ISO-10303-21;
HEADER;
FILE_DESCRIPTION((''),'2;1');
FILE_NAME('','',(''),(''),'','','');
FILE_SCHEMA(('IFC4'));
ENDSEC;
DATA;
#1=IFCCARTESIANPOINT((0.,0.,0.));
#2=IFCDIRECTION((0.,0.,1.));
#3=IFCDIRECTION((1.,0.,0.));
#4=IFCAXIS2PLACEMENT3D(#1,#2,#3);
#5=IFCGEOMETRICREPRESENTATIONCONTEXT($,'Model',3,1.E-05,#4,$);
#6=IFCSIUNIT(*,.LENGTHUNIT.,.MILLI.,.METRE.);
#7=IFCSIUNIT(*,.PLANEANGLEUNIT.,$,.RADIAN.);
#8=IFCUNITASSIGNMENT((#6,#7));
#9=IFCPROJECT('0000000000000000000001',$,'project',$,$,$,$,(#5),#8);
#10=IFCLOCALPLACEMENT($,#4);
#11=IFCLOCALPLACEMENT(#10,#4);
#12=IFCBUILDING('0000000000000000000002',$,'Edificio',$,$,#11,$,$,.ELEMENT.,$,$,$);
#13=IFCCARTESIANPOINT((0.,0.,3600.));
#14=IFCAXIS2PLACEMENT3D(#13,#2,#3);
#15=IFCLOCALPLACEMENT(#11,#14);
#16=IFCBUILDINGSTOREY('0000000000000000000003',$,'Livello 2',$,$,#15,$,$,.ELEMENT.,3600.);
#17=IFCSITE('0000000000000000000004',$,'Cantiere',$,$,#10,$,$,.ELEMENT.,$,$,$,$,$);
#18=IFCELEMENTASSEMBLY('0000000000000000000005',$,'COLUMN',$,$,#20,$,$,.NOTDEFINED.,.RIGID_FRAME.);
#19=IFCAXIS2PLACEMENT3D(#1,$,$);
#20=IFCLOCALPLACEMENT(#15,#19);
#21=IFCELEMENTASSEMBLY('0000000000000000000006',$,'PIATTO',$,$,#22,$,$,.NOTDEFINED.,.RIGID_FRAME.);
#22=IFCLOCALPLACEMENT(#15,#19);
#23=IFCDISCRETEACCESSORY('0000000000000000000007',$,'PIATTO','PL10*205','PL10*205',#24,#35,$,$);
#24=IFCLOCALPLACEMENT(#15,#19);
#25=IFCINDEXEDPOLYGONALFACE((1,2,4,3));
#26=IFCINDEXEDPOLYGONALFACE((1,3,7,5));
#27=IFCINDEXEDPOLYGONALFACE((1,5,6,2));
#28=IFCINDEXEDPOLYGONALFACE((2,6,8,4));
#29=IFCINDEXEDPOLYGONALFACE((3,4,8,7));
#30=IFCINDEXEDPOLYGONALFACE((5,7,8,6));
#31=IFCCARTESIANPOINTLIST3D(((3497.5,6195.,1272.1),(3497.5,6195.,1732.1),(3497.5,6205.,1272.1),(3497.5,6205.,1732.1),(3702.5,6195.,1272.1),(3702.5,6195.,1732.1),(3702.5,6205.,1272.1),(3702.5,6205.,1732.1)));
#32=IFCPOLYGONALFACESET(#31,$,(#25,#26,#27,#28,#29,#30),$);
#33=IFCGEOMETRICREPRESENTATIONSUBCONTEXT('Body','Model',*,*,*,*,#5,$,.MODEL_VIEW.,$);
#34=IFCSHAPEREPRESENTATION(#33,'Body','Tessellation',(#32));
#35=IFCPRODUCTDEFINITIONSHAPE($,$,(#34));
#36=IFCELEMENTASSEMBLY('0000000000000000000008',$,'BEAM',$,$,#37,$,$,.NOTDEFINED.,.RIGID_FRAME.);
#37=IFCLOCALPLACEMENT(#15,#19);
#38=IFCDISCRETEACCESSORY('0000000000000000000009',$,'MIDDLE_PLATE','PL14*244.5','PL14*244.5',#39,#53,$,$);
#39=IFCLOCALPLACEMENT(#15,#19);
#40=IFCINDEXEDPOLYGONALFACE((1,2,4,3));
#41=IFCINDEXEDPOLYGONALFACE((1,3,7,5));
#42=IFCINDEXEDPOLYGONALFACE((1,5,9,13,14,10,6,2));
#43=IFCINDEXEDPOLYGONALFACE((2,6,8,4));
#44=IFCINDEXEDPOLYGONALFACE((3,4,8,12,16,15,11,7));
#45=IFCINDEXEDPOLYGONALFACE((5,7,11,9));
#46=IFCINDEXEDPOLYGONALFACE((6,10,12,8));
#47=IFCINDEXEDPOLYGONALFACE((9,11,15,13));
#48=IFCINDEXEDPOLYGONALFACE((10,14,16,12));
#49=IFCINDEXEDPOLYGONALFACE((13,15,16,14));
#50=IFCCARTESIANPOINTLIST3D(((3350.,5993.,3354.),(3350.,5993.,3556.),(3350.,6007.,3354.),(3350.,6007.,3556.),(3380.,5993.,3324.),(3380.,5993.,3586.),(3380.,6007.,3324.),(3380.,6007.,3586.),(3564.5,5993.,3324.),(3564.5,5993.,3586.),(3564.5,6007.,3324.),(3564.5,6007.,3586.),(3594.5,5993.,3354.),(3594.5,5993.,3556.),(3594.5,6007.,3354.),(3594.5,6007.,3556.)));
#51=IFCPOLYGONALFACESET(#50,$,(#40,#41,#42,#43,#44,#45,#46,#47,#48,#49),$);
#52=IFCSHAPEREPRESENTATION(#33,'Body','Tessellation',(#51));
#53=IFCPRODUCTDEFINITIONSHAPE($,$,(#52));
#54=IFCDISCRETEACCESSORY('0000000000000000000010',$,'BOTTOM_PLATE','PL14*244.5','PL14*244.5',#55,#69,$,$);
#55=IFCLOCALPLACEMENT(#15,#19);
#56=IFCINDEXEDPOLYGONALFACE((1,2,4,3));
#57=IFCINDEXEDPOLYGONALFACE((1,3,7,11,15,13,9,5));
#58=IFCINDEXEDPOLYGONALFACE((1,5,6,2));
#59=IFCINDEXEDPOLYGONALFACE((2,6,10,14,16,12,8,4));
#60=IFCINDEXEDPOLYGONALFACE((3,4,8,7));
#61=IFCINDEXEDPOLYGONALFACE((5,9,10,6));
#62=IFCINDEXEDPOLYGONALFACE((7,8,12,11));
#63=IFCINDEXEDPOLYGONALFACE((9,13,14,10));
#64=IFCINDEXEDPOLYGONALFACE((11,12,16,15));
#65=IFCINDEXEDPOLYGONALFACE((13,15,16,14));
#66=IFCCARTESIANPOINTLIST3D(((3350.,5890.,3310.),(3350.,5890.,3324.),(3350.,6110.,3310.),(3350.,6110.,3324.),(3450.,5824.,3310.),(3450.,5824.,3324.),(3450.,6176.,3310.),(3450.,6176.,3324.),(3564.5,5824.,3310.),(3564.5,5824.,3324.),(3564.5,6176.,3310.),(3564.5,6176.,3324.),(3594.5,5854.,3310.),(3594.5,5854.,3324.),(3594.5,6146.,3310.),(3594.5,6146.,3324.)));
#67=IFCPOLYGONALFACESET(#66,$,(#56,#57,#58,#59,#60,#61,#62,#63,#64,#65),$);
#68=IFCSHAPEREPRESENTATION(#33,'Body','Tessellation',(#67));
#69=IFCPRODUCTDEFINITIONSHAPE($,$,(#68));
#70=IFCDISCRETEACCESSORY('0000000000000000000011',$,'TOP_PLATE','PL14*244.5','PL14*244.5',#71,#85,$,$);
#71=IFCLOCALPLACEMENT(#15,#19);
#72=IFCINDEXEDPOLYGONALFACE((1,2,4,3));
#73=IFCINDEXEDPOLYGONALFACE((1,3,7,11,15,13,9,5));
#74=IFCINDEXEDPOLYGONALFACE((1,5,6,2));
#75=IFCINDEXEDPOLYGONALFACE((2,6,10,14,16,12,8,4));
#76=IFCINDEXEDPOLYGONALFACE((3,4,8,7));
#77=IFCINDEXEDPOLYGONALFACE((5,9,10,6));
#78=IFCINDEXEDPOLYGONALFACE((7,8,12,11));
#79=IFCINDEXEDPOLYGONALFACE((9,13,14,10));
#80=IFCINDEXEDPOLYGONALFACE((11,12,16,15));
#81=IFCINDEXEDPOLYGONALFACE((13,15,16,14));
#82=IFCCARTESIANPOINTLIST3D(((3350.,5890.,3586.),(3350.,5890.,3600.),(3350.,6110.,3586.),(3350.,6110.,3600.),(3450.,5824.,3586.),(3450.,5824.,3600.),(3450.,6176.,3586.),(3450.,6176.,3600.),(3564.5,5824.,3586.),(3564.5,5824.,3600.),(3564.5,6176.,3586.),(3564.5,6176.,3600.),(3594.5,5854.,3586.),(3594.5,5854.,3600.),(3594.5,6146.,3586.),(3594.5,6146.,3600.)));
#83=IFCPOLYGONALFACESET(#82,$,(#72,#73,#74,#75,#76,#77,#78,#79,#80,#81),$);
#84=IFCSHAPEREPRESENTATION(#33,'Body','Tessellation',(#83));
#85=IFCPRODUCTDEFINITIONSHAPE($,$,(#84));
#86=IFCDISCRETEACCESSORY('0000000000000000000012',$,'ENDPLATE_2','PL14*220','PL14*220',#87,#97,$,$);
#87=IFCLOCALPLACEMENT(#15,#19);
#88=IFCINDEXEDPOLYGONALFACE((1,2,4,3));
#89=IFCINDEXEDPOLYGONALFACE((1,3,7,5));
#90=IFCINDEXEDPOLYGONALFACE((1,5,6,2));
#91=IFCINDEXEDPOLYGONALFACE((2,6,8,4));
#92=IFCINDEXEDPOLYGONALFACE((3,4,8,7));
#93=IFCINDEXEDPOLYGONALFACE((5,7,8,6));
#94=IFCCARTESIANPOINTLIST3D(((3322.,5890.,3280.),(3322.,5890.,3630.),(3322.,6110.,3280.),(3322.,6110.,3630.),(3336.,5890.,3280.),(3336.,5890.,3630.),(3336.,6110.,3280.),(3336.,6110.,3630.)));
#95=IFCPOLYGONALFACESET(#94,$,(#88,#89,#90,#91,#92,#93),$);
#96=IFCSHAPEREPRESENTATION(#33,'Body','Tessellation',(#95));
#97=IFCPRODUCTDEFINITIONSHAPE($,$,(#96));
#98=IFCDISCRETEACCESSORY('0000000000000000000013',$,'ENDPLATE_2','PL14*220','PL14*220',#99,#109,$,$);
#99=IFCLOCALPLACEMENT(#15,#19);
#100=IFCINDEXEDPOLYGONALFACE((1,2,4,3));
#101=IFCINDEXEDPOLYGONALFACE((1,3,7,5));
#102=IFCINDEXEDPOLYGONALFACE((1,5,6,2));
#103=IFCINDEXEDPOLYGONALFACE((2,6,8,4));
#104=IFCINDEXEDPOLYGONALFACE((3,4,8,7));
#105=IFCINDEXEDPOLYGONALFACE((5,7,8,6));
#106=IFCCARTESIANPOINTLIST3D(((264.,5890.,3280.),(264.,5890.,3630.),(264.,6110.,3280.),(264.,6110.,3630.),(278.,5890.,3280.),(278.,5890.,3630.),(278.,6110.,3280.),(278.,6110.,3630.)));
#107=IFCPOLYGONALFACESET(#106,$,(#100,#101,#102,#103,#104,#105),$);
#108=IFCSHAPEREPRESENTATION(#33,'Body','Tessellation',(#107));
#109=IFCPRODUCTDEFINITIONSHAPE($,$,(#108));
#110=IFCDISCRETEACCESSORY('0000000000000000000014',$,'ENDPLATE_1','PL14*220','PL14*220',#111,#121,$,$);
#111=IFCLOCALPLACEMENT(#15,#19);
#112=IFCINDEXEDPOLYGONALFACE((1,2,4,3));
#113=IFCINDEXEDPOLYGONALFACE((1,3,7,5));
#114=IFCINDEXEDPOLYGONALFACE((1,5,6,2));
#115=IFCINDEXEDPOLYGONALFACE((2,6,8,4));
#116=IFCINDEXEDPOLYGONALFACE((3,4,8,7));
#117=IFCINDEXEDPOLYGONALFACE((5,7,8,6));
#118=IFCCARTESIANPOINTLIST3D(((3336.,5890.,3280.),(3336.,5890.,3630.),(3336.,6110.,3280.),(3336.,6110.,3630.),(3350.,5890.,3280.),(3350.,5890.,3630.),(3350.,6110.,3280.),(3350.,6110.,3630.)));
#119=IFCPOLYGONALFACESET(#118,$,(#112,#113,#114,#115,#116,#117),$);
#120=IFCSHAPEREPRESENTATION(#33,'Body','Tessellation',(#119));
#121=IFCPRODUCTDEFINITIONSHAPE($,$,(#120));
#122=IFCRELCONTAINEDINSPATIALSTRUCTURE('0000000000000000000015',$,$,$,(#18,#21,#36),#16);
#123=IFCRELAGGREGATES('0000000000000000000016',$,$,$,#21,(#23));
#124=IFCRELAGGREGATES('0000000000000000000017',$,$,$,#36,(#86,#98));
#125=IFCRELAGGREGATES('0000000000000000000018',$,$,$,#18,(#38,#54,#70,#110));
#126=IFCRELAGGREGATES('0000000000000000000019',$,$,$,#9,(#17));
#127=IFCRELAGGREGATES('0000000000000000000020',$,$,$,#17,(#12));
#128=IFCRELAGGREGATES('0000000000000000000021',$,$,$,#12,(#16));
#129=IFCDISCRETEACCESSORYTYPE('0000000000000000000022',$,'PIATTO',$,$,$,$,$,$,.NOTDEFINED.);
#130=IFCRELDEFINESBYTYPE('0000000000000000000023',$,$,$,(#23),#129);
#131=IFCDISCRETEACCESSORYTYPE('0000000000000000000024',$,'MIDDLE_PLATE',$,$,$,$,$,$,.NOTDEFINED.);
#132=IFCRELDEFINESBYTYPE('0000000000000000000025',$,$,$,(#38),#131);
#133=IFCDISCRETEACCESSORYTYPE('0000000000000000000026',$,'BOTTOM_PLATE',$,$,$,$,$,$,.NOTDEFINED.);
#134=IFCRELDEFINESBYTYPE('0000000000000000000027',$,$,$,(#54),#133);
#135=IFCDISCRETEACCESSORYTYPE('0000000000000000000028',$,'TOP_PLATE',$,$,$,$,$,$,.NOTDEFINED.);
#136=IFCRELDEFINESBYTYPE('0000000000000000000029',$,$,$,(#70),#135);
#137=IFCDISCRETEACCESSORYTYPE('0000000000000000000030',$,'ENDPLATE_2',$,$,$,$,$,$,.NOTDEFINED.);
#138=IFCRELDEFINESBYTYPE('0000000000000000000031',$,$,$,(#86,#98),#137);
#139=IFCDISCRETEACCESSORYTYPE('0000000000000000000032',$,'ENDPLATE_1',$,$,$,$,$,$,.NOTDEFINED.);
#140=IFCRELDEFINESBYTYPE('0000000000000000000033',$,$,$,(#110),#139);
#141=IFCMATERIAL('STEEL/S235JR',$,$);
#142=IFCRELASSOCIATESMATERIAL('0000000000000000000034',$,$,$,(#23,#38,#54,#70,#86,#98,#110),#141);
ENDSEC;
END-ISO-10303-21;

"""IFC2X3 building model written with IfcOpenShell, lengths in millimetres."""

from ifc_helpers import new_model, si_unit, frame, origin_with_axes, place, context, subcontext, project, spatial, polyline, outline, extrude, material, type_object, element, aggregate, save


model = new_model("IFC2X3")

# Units and contexts
model_context = context("Model", 3, precision=1e-05, world=origin_with_axes())
body_context = subcontext(model_context, "Body", "Model", "MODEL_VIEW")
ifc_project = project(units=[si_unit("LENGTHUNIT", "METRE", prefix="MILLI"), si_unit("PLANEANGLEUNIT", "RADIAN")], contexts=[model_context])

# Site, building, storey
site_placement = place(None, origin_with_axes())
site = spatial("IfcSite", under=ifc_project, at=site_placement, Name="Cantiere", CompositionType="ELEMENT")
building_placement = place(site_placement, origin_with_axes())
building = spatial("IfcBuilding", under=site, at=building_placement, Name="Edificio", CompositionType="ELEMENT")
storey_placement = place(building_placement, frame((0.0, 0.0, 3600.0), z_axis=(0.0, 0.0, 1.0), x_axis=(1.0, 0.0, 0.0)))
storey = spatial("IfcBuildingStorey", under=building, at=storey_placement, Name="Livello 2", CompositionType="ELEMENT", Elevation=3600.0)

# Element assembly
assembly_1_placement = place(storey_placement, origin_with_axes())
assembly_1 = element("IfcElementAssembly", 1, at=assembly_1_placement, inside=storey, Name="COLUMN", AssemblyPlace="NOTDEFINED", PredefinedType="RIGID_FRAME")
ifc_material_1 = material(Name="STEEL/S235JR")

# Shared definitions
discrete_accessory_type_1 = type_object("IfcDiscreteAccessoryType", Name="PIATTO")

# Element assembly, discrete accessory
assembly_2_placement = place(storey_placement, origin_with_axes())
assembly_2 = element("IfcElementAssembly", 2, at=assembly_2_placement, inside=storey, Name="PIATTO", AssemblyPlace="NOTDEFINED", PredefinedType="RIGID_FRAME")
discrete_accessory_1_placement = place(assembly_2_placement, frame((3600.0, 6200.0, 1272.1), z_axis=(0.0, -1.0, 0.0), x_axis=(0.0, 0.0, 1.0)))
discrete_accessory_1 = element("IfcDiscreteAccessory", 3, at=discrete_accessory_1_placement, type_object=discrete_accessory_type_1, material=ifc_material_1, Name="PIATTO", Description="PL10*205", ObjectType="PL10*205", context=body_context, shape_type="SweptSolid", body=[
    extrude(outline(polyline([(0.0, 102.5), (460.0, 102.5), (460.0, -102.5), (0.0, -102.5), (0.0, 102.5)])), frame((0.0, 0.0, -5.0), z_axis=(0.0, 0.0, 1.0), x_axis=(1.0, 0.0, 0.0)), (0.0, 0.0, 1.0), 10.0),
])
aggregate(assembly_2, [discrete_accessory_1])

# Element assembly
assembly_3_placement = place(storey_placement, origin_with_axes())
assembly_3 = element("IfcElementAssembly", 4, at=assembly_3_placement, inside=storey, Name="BEAM", AssemblyPlace="NOTDEFINED", PredefinedType="RIGID_FRAME")

# Discrete accessories
discrete_accessory_type_2 = type_object("IfcDiscreteAccessoryType", Name="MIDDLE_PLATE")
discrete_accessory_2_placement = place(assembly_1_placement, frame((3350.0, 6000.0, 3586.0), z_axis=(0.0, 1.0, 0.0), x_axis=(1.0, 0.0, 0.0)))
discrete_accessory_2 = element("IfcDiscreteAccessory", 5, at=discrete_accessory_2_placement, type_object=discrete_accessory_type_2, material=ifc_material_1, Name="MIDDLE_PLATE", Description="PL14*244.5", ObjectType="PL14*244.5", context=body_context, shape_type="SweptSolid", body=[
    extrude(outline(polyline([(0.0, 30.0), (30.0, 0.0), (214.5, 0.0), (244.5, 30.0), (244.5, 232.0), (214.5, 262.0), (30.0, 262.0), (0.0, 232.0), (0.0, 30.0)])), frame((0.0, 0.0, -7.0), z_axis=(0.0, 0.0, 1.0), x_axis=(1.0, 0.0, 0.0)), (0.0, 0.0, 1.0), 14.0),
])
discrete_accessory_type_3 = type_object("IfcDiscreteAccessoryType", Name="BOTTOM_PLATE")
discrete_accessory_3_placement = place(assembly_1_placement, frame((3594.5, 5824.0, 3317.0), z_axis=(0.0, 0.0, 1.0), x_axis=(0.0, 1.0, 0.0)))
discrete_accessory_3 = element("IfcDiscreteAccessory", 6, at=discrete_accessory_3_placement, type_object=discrete_accessory_type_3, material=ifc_material_1, Name="BOTTOM_PLATE", Description="PL14*244.5", ObjectType="PL14*244.5", context=body_context, shape_type="SweptSolid", body=[
    extrude(outline(polyline([(0.0, 30.0), (30.0, 0.0), (322.0, 0.0), (352.0, 30.0), (352.0, 144.5), (286.0, 244.5), (66.0, 244.5), (0.0, 144.5), (0.0, 30.0)])), frame((0.0, 0.0, -7.0), z_axis=(0.0, 0.0, 1.0), x_axis=(1.0, 0.0, 0.0)), (0.0, 0.0, 1.0), 14.0),
])
discrete_accessory_type_4 = type_object("IfcDiscreteAccessoryType", Name="TOP_PLATE")
discrete_accessory_4_placement = place(assembly_1_placement, frame((3450.0, 5824.0, 3593.0), z_axis=(0.0, 0.0, 1.0), x_axis=(1.0, 0.0, 0.0)))
discrete_accessory_4 = element("IfcDiscreteAccessory", 7, at=discrete_accessory_4_placement, type_object=discrete_accessory_type_4, material=ifc_material_1, Name="TOP_PLATE", Description="PL14*244.5", ObjectType="PL14*244.5", context=body_context, shape_type="SweptSolid", body=[
    extrude(outline(polyline([(0.0, 0.0), (114.5, 0.0), (144.5, 30.0), (144.5, 322.0), (114.5, 352.0), (0.0, 352.0), (-100.0, 286.0), (-100.0, 66.0), (0.0, 0.0)])), frame((0.0, 0.0, -7.0), z_axis=(0.0, 0.0, 1.0), x_axis=(1.0, 0.0, 0.0)), (0.0, 0.0, 1.0), 14.0),
])
discrete_accessory_type_5 = type_object("IfcDiscreteAccessoryType", Name="ENDPLATE_2")
discrete_accessory_5_placement = place(assembly_3_placement, frame((3329.0, 5890.0, 3280.0), z_axis=(-1.0, 0.0, 0.0), x_axis=(0.0, 0.0, 1.0)))
discrete_accessory_5 = element("IfcDiscreteAccessory", 8, at=discrete_accessory_5_placement, type_object=discrete_accessory_type_5, material=ifc_material_1, Name="ENDPLATE_2", Description="PL14*220", ObjectType="PL14*220", context=body_context, shape_type="SweptSolid", body=[
    extrude(outline(polyline([(0.0, 0.0), (350.0, 0.0), (350.0, 220.0), (0.0, 220.0), (0.0, 0.0)])), frame((0.0, 0.0, -7.0), z_axis=(0.0, 0.0, 1.0), x_axis=(1.0, 0.0, 0.0)), (0.0, 0.0, 1.0), 14.0),
])
discrete_accessory_6_placement = place(assembly_3_placement, frame((271.0, 6110.0, 3280.0), z_axis=(1.0, 0.0, 0.0), x_axis=(0.0, 0.0, 1.0)))
discrete_accessory_6 = element("IfcDiscreteAccessory", 9, at=discrete_accessory_6_placement, type_object=discrete_accessory_type_5, material=ifc_material_1, Name="ENDPLATE_2", Description="PL14*220", ObjectType="PL14*220", context=body_context, shape_type="SweptSolid", body=[
    extrude(outline(polyline([(0.0, 0.0), (350.0, 0.0), (350.0, 220.0), (0.0, 220.0), (0.0, 0.0)])), frame((0.0, 0.0, -7.0), z_axis=(0.0, 0.0, 1.0), x_axis=(1.0, 0.0, 0.0)), (0.0, 0.0, 1.0), 14.0),
])
aggregate(assembly_3, [discrete_accessory_5, discrete_accessory_6])
discrete_accessory_type_6 = type_object("IfcDiscreteAccessoryType", Name="ENDPLATE_1")
discrete_accessory_7_placement = place(assembly_1_placement, frame((3343.0, 5890.0, 3280.0), z_axis=(-1.0, 0.0, 0.0), x_axis=(0.0, 0.0, 1.0)))
discrete_accessory_7 = element("IfcDiscreteAccessory", 10, at=discrete_accessory_7_placement, type_object=discrete_accessory_type_6, material=ifc_material_1, Name="ENDPLATE_1", Description="PL14*220", ObjectType="PL14*220", context=body_context, shape_type="SweptSolid", body=[
    extrude(outline(polyline([(0.0, 0.0), (350.0, 0.0), (350.0, 220.0), (0.0, 220.0), (0.0, 0.0)])), frame((0.0, 0.0, -7.0), z_axis=(0.0, 0.0, 1.0), x_axis=(1.0, 0.0, 0.0)), (0.0, 0.0, 1.0), 14.0),
])
aggregate(assembly_1, [discrete_accessory_2, discrete_accessory_3, discrete_accessory_4, discrete_accessory_7])

save(model, "model.ifc")
